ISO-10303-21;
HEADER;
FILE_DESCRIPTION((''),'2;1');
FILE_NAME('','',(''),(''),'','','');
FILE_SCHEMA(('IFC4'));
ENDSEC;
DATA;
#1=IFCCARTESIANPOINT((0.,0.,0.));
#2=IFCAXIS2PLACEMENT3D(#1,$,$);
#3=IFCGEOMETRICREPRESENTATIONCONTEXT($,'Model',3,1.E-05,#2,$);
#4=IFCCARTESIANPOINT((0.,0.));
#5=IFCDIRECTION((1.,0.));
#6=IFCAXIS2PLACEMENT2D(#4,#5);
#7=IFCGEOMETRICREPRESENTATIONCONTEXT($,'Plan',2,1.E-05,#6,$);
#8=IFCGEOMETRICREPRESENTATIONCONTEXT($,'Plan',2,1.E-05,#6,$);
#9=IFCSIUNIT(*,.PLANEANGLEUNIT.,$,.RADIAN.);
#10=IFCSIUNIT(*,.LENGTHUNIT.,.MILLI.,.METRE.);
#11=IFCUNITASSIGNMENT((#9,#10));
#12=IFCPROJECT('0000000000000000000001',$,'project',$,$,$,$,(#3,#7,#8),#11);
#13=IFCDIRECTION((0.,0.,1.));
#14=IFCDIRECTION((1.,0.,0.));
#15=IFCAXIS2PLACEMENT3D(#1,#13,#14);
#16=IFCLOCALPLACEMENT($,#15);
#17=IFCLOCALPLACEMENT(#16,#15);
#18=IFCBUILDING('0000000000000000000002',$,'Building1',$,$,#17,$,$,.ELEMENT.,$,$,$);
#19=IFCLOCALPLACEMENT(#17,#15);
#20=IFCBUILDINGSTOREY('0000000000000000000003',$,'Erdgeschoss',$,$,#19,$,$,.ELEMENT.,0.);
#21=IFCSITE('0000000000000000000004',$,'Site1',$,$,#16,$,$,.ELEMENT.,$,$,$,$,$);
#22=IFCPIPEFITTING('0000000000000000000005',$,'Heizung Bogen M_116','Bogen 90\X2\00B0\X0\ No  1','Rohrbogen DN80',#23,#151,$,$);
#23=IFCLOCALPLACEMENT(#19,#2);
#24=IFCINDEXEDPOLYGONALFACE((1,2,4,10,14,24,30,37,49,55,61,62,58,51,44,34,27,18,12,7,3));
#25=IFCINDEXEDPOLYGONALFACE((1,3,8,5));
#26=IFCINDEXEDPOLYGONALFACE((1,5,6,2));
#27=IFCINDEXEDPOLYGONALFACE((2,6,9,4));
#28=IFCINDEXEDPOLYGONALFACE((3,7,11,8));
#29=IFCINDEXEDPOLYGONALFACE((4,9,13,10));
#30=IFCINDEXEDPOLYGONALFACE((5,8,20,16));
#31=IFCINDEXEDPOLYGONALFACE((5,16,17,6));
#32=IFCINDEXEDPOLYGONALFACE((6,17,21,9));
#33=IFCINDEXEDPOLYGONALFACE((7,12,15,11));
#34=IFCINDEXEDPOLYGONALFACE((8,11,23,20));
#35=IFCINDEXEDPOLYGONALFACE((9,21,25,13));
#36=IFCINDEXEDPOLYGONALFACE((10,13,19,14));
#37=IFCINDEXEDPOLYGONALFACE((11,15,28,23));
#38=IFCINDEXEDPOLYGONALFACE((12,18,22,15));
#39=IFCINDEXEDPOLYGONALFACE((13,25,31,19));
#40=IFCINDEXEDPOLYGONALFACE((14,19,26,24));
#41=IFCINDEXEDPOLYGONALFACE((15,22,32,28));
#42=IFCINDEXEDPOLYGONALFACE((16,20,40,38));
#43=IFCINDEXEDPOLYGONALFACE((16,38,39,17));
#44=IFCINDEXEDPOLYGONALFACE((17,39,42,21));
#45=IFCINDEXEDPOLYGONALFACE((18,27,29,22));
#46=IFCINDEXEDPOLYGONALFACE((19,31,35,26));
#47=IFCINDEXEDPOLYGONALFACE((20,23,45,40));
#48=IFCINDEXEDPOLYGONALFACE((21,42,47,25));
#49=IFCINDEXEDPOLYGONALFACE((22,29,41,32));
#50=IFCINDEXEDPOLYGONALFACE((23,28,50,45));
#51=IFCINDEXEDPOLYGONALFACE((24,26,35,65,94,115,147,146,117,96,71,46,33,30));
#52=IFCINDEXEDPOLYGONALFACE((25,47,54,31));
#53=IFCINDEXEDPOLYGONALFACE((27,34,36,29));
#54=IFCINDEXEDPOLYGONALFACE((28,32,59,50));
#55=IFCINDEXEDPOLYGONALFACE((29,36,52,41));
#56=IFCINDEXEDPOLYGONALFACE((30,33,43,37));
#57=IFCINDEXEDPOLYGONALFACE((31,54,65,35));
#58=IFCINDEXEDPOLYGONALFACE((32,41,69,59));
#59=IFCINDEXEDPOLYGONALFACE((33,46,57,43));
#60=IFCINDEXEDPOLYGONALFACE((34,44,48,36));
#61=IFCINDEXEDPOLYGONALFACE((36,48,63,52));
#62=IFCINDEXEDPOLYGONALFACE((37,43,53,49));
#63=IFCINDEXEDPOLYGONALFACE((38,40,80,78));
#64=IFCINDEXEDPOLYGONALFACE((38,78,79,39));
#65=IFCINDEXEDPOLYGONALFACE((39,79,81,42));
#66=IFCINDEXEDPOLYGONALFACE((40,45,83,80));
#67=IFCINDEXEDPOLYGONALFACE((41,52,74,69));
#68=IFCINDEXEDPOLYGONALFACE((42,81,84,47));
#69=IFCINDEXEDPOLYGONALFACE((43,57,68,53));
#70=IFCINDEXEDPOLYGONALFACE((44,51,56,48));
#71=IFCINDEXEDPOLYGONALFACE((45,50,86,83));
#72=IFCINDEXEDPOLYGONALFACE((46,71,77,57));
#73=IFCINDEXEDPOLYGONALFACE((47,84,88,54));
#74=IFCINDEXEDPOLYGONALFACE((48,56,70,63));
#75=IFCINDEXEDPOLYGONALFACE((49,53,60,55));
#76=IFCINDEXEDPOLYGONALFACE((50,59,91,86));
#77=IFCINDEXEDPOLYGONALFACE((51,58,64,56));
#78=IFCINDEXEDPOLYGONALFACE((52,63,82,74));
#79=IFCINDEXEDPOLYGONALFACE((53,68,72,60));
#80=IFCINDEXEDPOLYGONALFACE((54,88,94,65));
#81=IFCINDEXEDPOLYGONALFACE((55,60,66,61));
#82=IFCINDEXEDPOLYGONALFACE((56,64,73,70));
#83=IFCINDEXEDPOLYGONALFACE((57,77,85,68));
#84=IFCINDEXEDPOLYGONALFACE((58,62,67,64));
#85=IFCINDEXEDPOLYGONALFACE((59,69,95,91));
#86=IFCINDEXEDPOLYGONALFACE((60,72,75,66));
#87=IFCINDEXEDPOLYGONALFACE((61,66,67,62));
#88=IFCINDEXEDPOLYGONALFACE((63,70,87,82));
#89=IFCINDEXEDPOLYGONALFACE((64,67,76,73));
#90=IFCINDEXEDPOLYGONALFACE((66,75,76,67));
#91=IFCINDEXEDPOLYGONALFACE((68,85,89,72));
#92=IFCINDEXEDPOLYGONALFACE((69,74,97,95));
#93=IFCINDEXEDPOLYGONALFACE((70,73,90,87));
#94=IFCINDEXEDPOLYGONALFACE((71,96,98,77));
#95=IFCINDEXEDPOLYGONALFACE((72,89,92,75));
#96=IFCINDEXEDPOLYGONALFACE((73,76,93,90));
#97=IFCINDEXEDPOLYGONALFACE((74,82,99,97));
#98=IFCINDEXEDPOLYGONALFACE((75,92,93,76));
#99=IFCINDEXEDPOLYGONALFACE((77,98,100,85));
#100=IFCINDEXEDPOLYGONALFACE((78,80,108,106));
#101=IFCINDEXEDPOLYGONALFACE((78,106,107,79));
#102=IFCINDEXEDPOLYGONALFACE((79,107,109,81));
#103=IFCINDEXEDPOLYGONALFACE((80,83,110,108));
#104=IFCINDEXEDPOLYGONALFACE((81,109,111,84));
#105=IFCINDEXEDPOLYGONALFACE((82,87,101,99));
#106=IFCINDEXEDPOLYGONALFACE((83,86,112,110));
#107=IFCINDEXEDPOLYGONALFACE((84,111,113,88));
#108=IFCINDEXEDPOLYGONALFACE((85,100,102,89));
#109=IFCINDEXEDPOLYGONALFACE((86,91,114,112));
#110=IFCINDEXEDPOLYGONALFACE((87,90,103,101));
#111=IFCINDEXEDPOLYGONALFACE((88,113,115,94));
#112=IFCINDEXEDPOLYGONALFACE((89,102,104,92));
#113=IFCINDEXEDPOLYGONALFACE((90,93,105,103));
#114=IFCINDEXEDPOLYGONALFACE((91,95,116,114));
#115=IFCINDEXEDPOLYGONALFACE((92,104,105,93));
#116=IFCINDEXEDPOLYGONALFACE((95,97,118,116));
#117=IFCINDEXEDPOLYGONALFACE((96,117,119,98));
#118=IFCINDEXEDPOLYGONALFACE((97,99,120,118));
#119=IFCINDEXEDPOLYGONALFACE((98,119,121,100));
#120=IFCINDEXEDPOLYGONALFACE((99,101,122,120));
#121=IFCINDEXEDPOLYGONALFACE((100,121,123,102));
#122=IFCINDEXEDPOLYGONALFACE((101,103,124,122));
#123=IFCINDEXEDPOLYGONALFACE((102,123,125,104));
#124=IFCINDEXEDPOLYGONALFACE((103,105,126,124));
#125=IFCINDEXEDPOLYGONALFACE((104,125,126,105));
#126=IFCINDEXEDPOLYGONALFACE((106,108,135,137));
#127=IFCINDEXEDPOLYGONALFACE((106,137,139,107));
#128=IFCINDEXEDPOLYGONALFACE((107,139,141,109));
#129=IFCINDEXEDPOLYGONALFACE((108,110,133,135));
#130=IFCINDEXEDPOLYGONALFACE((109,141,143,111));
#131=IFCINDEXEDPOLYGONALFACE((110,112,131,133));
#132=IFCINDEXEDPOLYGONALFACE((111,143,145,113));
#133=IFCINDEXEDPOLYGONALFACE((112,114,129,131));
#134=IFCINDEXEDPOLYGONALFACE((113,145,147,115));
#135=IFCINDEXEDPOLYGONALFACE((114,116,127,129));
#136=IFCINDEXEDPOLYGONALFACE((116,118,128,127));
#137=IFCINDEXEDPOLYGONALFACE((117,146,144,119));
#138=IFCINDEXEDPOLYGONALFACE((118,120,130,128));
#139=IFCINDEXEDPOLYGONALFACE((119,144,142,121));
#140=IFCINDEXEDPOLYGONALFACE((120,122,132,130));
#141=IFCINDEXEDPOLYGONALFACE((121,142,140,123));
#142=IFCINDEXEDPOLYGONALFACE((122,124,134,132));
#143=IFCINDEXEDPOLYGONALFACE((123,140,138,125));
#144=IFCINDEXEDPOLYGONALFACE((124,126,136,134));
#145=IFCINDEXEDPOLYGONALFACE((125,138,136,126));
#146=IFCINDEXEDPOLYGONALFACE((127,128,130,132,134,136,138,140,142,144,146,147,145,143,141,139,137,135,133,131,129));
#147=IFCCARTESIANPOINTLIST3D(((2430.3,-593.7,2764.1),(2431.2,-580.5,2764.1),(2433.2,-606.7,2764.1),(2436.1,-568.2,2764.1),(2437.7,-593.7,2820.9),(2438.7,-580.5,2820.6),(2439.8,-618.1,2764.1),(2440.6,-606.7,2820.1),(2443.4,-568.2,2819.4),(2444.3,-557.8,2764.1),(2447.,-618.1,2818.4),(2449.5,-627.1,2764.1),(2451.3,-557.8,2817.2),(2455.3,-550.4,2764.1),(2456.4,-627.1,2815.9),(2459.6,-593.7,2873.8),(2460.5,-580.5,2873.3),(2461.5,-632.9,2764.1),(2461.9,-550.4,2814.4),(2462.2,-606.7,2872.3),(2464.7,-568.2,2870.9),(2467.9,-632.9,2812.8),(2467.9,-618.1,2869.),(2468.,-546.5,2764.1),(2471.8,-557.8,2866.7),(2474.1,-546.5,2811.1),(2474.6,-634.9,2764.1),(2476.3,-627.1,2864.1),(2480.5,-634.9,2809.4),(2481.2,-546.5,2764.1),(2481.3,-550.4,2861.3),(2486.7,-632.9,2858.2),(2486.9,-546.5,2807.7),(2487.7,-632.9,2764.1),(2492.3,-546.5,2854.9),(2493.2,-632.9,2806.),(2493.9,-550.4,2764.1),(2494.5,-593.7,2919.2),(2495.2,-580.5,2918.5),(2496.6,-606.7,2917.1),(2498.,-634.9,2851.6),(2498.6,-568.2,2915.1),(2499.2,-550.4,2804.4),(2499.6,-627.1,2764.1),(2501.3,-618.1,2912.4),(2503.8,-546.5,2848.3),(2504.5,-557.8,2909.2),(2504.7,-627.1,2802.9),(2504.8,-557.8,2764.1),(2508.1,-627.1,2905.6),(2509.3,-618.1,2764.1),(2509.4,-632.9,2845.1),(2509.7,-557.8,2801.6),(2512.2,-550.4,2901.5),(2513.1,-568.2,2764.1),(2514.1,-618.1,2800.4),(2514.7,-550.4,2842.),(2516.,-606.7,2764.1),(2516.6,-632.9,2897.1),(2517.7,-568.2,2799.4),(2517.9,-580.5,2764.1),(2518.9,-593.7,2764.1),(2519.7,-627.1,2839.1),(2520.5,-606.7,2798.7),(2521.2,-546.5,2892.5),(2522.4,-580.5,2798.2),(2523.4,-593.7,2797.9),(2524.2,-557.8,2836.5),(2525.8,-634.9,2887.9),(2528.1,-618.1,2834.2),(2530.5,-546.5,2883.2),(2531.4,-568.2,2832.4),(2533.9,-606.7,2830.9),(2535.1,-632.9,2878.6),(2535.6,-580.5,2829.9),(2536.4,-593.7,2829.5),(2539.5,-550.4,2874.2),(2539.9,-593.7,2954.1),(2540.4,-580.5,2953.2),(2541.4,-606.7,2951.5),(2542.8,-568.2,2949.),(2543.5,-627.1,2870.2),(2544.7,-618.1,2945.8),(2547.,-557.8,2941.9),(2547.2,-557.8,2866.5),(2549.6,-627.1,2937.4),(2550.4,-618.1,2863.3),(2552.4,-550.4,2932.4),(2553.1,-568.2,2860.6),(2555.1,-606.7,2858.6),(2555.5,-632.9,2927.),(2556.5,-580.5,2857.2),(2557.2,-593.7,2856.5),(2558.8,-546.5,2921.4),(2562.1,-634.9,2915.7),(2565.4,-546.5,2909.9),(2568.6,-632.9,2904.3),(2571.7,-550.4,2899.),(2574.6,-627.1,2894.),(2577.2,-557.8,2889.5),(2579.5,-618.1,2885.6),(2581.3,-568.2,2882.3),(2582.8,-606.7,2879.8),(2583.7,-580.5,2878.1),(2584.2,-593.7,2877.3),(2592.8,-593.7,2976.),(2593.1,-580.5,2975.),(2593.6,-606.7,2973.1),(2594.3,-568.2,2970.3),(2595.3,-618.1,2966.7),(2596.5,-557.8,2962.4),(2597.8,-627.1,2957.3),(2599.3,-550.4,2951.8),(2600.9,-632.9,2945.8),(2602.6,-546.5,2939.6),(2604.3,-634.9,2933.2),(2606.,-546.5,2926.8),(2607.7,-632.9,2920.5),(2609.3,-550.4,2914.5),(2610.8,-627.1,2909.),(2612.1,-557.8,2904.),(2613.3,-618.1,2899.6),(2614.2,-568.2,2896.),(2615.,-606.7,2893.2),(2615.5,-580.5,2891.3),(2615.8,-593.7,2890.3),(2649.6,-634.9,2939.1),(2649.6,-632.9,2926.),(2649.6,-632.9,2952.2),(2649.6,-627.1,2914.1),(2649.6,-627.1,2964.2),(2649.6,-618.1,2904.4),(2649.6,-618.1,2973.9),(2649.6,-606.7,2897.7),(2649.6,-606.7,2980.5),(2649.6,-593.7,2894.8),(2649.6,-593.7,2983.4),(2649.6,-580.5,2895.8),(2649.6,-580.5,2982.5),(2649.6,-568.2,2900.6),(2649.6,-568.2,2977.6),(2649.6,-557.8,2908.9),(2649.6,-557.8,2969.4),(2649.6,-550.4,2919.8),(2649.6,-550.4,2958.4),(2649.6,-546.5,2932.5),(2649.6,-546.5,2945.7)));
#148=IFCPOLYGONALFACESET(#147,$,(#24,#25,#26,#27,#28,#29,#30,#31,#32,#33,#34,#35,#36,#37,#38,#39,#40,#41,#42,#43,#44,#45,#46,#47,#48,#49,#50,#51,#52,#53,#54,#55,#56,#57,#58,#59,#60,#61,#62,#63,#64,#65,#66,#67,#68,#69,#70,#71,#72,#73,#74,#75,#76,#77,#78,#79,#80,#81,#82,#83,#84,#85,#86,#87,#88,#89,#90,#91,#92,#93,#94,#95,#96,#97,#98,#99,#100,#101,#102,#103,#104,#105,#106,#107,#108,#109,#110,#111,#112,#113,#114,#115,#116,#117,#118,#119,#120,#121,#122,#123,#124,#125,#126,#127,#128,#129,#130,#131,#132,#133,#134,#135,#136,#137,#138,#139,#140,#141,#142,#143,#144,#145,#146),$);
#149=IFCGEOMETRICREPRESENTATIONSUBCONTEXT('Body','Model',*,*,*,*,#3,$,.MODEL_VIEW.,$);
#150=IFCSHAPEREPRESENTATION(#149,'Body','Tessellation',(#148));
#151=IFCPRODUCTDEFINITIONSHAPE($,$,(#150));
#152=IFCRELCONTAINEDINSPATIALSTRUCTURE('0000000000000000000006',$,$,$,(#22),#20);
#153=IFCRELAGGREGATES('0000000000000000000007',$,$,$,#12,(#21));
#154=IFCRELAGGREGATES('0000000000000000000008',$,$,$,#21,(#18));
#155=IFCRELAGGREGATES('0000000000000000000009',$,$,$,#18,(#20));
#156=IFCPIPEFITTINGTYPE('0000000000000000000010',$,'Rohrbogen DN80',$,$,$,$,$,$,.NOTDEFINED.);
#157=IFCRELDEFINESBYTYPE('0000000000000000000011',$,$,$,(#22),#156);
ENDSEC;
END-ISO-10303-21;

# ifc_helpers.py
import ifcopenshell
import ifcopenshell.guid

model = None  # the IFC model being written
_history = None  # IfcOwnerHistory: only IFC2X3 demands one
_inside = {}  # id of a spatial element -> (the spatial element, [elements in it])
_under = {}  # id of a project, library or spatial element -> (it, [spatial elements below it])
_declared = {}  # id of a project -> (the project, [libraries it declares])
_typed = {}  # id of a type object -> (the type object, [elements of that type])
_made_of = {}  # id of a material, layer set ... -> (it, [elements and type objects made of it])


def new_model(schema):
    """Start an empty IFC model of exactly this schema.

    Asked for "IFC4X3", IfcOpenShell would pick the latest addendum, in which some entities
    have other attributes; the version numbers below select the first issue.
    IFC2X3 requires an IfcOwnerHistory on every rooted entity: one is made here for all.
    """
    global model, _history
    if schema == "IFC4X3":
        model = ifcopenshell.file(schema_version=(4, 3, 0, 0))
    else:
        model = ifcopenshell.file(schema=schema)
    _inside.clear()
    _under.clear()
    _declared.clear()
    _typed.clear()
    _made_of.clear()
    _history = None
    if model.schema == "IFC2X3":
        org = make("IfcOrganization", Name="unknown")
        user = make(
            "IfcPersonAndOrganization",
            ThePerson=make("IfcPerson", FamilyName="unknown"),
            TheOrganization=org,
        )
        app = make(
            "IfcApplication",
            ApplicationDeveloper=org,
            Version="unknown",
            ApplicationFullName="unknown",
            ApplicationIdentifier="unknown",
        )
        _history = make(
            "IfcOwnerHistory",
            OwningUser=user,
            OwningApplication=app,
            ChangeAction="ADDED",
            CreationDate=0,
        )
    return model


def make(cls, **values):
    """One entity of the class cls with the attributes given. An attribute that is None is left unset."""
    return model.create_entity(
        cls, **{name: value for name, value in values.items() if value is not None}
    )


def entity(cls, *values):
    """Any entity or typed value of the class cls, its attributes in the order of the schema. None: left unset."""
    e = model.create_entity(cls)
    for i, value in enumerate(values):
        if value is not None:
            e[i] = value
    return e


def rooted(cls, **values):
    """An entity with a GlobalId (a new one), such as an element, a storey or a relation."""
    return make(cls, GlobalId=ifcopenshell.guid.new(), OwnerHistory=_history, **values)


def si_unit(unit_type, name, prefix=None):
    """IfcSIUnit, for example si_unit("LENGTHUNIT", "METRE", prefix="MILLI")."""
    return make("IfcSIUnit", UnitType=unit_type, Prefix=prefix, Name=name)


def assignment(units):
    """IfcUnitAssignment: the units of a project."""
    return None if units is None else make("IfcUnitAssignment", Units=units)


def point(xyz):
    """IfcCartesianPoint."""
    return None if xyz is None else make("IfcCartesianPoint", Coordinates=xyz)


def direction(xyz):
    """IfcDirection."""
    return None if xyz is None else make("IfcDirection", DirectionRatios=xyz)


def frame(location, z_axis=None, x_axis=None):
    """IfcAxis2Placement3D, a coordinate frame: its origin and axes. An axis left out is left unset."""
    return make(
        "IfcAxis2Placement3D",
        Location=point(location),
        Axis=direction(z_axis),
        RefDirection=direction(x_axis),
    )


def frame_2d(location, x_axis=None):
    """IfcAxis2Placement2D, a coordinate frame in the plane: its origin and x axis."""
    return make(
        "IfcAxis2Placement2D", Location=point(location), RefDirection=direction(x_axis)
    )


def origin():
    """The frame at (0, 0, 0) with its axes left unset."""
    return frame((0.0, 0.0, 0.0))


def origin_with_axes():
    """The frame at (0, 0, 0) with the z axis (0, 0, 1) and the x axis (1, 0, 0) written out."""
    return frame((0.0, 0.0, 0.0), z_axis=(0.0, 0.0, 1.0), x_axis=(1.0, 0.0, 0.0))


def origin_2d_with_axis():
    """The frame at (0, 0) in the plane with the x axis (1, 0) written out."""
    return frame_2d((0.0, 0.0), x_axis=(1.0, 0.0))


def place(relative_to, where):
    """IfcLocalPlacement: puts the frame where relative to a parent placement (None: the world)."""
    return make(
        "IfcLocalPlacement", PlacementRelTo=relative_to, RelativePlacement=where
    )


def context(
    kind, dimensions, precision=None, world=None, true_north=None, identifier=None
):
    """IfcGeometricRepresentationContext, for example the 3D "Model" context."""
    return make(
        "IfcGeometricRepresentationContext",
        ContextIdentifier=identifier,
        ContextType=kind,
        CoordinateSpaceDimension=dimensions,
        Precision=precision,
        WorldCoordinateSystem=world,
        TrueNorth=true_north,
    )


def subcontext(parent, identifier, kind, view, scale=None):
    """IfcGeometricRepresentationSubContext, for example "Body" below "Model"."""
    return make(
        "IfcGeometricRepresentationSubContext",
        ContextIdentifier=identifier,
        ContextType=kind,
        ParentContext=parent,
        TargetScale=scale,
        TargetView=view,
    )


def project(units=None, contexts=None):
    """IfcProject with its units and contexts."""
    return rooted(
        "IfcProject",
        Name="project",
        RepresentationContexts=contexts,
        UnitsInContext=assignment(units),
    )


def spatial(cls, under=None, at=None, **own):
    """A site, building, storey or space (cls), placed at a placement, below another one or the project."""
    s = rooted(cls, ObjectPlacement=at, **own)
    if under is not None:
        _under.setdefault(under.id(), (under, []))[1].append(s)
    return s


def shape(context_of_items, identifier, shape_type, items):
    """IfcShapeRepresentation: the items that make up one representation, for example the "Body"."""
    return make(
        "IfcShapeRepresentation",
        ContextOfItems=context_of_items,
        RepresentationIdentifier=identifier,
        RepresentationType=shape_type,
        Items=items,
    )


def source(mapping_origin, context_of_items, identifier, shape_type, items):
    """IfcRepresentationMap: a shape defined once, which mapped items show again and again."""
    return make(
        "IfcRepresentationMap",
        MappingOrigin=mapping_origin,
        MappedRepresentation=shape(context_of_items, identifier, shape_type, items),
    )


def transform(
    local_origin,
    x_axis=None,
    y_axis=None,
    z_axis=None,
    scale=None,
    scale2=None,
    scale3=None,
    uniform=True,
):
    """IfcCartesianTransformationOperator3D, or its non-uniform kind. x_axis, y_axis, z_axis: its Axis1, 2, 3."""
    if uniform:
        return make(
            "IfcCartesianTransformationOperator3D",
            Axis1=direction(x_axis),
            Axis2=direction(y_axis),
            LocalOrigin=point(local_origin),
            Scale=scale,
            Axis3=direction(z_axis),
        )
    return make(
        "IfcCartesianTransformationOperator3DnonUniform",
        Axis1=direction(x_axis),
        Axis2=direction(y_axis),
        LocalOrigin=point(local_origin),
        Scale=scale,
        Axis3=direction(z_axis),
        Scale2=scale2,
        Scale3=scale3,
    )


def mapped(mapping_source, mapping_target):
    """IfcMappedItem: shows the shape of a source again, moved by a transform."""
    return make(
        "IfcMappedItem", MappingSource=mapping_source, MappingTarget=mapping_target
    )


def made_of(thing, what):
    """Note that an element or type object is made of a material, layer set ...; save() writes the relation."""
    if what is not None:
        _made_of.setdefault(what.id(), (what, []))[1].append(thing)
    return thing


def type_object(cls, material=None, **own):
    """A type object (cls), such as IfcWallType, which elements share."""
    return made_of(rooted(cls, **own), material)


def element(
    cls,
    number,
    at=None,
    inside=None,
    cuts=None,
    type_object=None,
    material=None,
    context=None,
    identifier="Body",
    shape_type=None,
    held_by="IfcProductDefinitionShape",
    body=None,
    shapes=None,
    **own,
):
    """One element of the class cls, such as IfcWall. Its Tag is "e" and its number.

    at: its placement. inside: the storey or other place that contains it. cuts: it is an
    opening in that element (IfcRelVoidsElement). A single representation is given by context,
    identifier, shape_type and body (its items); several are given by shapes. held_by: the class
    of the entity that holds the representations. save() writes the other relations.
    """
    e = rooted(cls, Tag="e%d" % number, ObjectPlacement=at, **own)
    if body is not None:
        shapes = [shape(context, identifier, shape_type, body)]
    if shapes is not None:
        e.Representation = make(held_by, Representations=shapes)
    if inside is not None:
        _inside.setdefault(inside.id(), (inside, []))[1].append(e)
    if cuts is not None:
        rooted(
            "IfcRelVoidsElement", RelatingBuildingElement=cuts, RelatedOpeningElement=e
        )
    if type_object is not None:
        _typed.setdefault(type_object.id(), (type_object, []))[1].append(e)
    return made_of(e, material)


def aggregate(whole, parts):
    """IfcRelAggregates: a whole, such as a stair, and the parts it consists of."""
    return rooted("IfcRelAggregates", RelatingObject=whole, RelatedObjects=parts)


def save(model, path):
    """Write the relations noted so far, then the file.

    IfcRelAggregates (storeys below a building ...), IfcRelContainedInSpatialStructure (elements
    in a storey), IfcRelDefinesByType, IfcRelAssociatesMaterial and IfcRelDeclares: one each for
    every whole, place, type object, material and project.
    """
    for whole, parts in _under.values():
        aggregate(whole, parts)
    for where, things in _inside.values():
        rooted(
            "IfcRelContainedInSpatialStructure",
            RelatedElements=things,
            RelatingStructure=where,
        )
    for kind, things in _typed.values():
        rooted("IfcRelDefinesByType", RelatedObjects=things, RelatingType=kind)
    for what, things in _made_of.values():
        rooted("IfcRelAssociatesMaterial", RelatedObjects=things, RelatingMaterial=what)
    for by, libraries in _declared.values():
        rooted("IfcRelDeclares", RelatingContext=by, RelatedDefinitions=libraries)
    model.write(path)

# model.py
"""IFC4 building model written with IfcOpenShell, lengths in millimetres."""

from ifc_helpers import new_model, entity, si_unit, frame, origin, origin_with_axes, origin_2d_with_axis, place, context, subcontext, project, spatial, source, transform, mapped, type_object, element, save


model = new_model("IFC4")

# Units and contexts
model_context = context("Model", 3, precision=1e-05, world=origin())
plan_context_1 = context("Plan", 2, precision=1e-05, world=origin_2d_with_axis())
plan_context_2 = context("Plan", 2, precision=1e-05, world=origin_2d_with_axis())
body_context = subcontext(model_context, "Body", "Model", "MODEL_VIEW")
ifc_project = project(units=[si_unit("PLANEANGLEUNIT", "RADIAN"), si_unit("LENGTHUNIT", "METRE", prefix="MILLI")], contexts=[model_context, plan_context_1, plan_context_2])

# Site, building, storey
site_placement = place(None, origin_with_axes())
site = spatial("IfcSite", under=ifc_project, at=site_placement, Name="Site1", CompositionType="ELEMENT")
building_placement = place(site_placement, origin_with_axes())
building = spatial("IfcBuilding", under=site, at=building_placement, Name="Building1", CompositionType="ELEMENT")
storey_placement = place(building_placement, origin_with_axes())
storey = spatial("IfcBuildingStorey", under=building, at=storey_placement, Name="Erdgeschoss", CompositionType="ELEMENT", Elevation=0.0)

# Shared definitions
pipe_fitting_type_1 = type_object("IfcPipeFittingType", Name="Rohrbogen DN80", PredefinedType="NOTDEFINED")

# Pipe fitting
shared_shape_1 = source(origin_with_axes(), body_context, "Body", "SolidModel", [
    entity("IfcRevolvedAreaSolid", entity("IfcCircleProfileDef", "AREA", None, entity("IfcAxis2Placement2D", entity("IfcCartesianPoint", [0.0, 0.0]), entity("IfcDirection", [1.0, 0.0])), 44.5), entity("IfcAxis2Placement3D", entity("IfcCartesianPoint", [109.7, -65.3, 0.0]), entity("IfcDirection", [-1.0, 0.0, 0.0]), entity("IfcDirection", [0.0, 0.0, 1.0])), entity("IfcAxis1Placement", entity("IfcCartesianPoint", [0.0, 175.0, 0.0]), entity("IfcDirection", [-1.0, 0.0, 0.0])), 1.570796),
])
pipe_fitting_1_placement = place(storey_placement, frame((2539.9, -590.4, 2873.8), z_axis=(0.0, 0.0, 1.0), x_axis=(1.0, 0.0, 0.0)))
element("IfcPipeFitting", 1, at=pipe_fitting_1_placement, inside=storey, type_object=pipe_fitting_type_1, Name="Heizung Bogen M_116", Description="Bogen 90° No  1", ObjectType="Rohrbogen DN80", context=body_context, shape_type="MappedRepresentation", body=[
    mapped(shared_shape_1, transform((0.0, 0.0, 0.0), x_axis=(0.0, 0.0, -1.0), y_axis=(1.0, 0.0, 0.0), z_axis=(0.0, -1.0, 0.0), scale=1.0)),
])

save(model, "model.ifc")
